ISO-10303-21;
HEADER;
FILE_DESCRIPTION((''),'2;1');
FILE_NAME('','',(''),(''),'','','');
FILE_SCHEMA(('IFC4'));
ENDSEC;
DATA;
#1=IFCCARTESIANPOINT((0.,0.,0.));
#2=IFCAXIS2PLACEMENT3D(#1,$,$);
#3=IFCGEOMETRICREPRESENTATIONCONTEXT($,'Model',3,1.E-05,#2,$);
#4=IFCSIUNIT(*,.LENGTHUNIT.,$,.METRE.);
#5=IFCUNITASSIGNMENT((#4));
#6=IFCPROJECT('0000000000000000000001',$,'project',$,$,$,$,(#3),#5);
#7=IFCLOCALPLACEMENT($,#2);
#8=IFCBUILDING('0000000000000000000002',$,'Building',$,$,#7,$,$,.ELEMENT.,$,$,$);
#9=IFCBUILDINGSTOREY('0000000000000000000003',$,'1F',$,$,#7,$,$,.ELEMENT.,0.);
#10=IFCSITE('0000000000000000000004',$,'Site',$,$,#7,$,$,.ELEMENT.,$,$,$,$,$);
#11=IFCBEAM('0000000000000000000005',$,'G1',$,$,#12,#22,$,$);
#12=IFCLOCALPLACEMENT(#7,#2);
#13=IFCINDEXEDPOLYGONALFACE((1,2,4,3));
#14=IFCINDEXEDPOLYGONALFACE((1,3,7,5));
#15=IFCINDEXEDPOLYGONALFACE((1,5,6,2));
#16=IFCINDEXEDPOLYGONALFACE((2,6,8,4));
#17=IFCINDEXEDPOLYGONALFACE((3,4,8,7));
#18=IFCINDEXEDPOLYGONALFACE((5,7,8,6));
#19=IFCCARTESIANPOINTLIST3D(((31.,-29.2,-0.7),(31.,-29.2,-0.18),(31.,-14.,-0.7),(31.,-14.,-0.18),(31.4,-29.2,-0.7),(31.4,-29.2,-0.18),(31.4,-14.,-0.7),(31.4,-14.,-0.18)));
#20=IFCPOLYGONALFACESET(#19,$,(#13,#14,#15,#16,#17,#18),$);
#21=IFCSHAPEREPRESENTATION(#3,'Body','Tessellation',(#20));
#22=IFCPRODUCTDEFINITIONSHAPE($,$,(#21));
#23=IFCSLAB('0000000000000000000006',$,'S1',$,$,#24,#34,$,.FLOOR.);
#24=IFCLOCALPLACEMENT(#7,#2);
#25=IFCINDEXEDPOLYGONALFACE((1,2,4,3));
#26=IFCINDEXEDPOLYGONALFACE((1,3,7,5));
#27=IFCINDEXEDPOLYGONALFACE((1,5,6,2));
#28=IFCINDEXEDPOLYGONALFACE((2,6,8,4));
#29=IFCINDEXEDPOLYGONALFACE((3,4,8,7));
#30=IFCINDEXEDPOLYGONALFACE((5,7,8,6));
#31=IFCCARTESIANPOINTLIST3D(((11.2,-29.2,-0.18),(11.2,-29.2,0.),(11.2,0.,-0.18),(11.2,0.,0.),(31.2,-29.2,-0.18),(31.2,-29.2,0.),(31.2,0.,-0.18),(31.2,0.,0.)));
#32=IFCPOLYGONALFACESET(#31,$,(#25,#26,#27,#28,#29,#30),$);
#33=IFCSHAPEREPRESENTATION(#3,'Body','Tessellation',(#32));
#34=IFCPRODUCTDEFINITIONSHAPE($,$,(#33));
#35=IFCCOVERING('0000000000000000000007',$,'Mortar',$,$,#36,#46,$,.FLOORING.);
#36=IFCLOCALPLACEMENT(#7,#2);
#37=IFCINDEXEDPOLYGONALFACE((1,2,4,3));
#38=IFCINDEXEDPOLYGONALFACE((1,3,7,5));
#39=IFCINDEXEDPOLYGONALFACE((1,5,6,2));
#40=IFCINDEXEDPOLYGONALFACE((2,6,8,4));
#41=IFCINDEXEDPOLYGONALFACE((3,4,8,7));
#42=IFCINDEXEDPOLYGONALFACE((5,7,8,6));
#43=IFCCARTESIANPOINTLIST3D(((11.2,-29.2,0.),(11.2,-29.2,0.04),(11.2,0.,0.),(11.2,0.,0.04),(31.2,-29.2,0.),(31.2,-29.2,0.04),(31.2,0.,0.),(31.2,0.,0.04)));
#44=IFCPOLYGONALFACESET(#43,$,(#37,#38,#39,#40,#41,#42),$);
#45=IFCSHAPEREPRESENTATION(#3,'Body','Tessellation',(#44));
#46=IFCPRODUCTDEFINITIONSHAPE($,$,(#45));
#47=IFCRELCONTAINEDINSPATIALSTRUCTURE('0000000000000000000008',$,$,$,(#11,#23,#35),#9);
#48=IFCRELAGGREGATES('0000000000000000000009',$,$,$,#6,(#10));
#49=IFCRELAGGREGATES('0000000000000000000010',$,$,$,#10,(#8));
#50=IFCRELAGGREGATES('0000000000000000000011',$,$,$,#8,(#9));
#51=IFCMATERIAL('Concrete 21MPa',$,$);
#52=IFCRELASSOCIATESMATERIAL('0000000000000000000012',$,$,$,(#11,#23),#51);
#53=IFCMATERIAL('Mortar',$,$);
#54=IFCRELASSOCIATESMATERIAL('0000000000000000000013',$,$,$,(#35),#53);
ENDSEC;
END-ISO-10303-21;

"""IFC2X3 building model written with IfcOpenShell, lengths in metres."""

from ifc_helpers import new_model, si_unit, frame, origin, origin_2d, place, context, project, spatial, rectangle, extrude, material, element, save


model = new_model("IFC2X3")

# Units and contexts
model_context = context("Model", 3, precision=1e-05, world=origin())
ifc_project = project(units=[si_unit("LENGTHUNIT", "METRE")], contexts=[model_context])

# Site, building, storey
placement = place(None, origin())
site = spatial("IfcSite", under=ifc_project, at=placement, Name="Site", CompositionType="ELEMENT")
building = spatial("IfcBuilding", under=site, at=placement, Name="Building", CompositionType="ELEMENT")
storey = spatial("IfcBuildingStorey", under=building, at=placement, Name="1F", CompositionType="ELEMENT", Elevation=0.0)

# Shared definitions
ifc_material_1 = material(Name="Concrete 21MPa")

# Beam
for number, where, name in (
    (1, (31.2, -21.6, -0.7), "G1"),
):
    element("IfcBeam", number, at=place(None, frame(where)), inside=storey, material=ifc_material_1, Name=name, context=model_context, shape_type="SweptSolid", body=[
        extrude(rectangle(XDim=0.4, YDim=15.2, at=origin_2d()), origin(), (0.0, 0.0, 1.0), 0.52),
    ])

# Slab
slab_placement = place(None, frame((21.2, -14.6, -0.18)))
element("IfcSlab", 2, at=slab_placement, inside=storey, material=ifc_material_1, Name="S1", PredefinedType="FLOOR", context=model_context, shape_type="SweptSolid", body=[
    extrude(rectangle(XDim=20.0, YDim=29.2, at=origin_2d()), origin(), (0.0, 0.0, 1.0), 0.18),
])

# Covering
ifc_material_2 = material(Name="Mortar")
covering_placement = place(None, frame((21.2, -14.6, 0.0)))
element("IfcCovering", 3, at=covering_placement, inside=storey, material=ifc_material_2, Name="Mortar", PredefinedType="FLOORING", context=model_context, shape_type="SweptSolid", body=[
    extrude(rectangle(XDim=20.0, YDim=29.2, at=origin_2d()), origin(), (0.0, 0.0, 1.0), 0.04),
])

save(model, "model.ifc")
